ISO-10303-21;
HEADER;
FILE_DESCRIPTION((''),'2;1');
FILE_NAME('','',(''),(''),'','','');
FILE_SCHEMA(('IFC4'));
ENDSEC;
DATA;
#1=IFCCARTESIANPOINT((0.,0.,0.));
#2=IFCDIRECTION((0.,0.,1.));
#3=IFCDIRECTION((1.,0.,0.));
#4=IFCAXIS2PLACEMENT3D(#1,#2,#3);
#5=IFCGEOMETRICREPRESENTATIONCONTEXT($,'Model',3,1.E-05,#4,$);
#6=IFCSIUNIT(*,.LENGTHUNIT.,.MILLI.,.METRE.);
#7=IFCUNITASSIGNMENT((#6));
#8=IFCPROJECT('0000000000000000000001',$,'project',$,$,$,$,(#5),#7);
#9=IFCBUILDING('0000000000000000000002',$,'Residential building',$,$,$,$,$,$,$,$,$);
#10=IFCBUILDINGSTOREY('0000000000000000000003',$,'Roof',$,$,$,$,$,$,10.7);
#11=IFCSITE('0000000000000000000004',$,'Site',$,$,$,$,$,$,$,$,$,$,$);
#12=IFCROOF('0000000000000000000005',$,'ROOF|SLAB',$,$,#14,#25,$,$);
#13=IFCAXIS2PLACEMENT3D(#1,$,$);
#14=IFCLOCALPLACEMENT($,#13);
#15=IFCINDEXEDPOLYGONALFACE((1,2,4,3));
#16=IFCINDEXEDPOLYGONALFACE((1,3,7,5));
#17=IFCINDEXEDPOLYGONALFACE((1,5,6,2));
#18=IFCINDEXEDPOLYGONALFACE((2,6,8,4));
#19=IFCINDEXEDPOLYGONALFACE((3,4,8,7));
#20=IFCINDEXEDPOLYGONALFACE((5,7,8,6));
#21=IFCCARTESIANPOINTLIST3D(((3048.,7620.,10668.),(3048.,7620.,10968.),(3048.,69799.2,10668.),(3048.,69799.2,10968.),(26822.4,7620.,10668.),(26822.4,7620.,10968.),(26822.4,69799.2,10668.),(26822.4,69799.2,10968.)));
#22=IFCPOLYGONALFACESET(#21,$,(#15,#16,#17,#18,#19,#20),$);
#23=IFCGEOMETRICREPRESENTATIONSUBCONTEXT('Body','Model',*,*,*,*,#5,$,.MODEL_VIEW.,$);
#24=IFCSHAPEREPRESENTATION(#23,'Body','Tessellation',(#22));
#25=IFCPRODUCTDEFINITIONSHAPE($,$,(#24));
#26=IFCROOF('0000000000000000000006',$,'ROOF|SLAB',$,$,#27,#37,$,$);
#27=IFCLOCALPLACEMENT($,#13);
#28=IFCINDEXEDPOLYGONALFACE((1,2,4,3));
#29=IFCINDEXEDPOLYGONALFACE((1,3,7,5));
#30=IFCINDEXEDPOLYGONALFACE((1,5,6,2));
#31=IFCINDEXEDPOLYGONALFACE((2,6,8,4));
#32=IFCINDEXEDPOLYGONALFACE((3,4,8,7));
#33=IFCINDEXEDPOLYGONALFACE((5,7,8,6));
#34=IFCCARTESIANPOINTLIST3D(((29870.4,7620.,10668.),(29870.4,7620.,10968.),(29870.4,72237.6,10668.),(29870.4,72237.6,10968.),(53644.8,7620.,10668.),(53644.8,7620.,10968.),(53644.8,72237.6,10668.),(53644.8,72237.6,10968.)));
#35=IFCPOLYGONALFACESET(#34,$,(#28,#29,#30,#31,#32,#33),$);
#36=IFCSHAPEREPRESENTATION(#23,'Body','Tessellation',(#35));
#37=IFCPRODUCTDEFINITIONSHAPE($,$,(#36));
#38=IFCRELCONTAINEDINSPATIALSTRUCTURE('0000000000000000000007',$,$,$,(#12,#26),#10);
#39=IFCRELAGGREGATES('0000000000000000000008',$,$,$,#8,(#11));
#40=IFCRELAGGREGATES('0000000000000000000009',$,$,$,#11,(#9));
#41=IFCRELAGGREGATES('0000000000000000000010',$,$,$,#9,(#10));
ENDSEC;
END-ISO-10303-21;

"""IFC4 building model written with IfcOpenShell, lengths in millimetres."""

from ifc_helpers import new_model, si_unit, frame, origin_with_axes, place, context, subcontext, project, spatial, indexed_curve, outline, extrude, element, save


model = new_model("IFC4")

# Units and contexts
model_context = context("Model", 3, precision=1e-05, world=origin_with_axes())
body_context = subcontext(model_context, "Body", "Model", "MODEL_VIEW")
ifc_project = project(units=[si_unit("LENGTHUNIT", "METRE", prefix="MILLI")], contexts=[model_context])

# Site, building, storey
site = spatial("IfcSite", under=ifc_project, Name="Site")
building = spatial("IfcBuilding", under=site, Name="Residential building")
storey = spatial("IfcBuildingStorey", under=building, Name="Roof", Elevation=10.7)

# Roofs
roof_1_placement = place(None, frame((3048.0, 7620.0, 10668.0), z_axis=(0.0, 0.0, 1.0), x_axis=(1.0, 0.0, 0.0)))
element("IfcRoof", 1, at=roof_1_placement, inside=storey, Name="ROOF|SLAB", context=body_context, shape_type="SweptSolid", body=[
    extrude(outline(indexed_curve([(0.0, 0.0), (23774.4, 0.0), (23774.4, 62179.2), (0.0, 62179.2), (0.0, 0.0)])), None, (0.0, 0.0, 1.0), 300.0),
])
roof_2_placement = place(None, frame((29870.4, 7620.0, 10668.0), z_axis=(0.0, 0.0, 1.0), x_axis=(1.0, 0.0, 0.0)))
element("IfcRoof", 2, at=roof_2_placement, inside=storey, Name="ROOF|SLAB", context=body_context, shape_type="SweptSolid", body=[
    extrude(outline(indexed_curve([(0.0, 0.0), (23774.4, 0.0), (23774.4, 64617.6), (0.0, 64617.6), (0.0, 0.0)])), None, (0.0, 0.0, 1.0), 300.0),
])

save(model, "model.ifc")
